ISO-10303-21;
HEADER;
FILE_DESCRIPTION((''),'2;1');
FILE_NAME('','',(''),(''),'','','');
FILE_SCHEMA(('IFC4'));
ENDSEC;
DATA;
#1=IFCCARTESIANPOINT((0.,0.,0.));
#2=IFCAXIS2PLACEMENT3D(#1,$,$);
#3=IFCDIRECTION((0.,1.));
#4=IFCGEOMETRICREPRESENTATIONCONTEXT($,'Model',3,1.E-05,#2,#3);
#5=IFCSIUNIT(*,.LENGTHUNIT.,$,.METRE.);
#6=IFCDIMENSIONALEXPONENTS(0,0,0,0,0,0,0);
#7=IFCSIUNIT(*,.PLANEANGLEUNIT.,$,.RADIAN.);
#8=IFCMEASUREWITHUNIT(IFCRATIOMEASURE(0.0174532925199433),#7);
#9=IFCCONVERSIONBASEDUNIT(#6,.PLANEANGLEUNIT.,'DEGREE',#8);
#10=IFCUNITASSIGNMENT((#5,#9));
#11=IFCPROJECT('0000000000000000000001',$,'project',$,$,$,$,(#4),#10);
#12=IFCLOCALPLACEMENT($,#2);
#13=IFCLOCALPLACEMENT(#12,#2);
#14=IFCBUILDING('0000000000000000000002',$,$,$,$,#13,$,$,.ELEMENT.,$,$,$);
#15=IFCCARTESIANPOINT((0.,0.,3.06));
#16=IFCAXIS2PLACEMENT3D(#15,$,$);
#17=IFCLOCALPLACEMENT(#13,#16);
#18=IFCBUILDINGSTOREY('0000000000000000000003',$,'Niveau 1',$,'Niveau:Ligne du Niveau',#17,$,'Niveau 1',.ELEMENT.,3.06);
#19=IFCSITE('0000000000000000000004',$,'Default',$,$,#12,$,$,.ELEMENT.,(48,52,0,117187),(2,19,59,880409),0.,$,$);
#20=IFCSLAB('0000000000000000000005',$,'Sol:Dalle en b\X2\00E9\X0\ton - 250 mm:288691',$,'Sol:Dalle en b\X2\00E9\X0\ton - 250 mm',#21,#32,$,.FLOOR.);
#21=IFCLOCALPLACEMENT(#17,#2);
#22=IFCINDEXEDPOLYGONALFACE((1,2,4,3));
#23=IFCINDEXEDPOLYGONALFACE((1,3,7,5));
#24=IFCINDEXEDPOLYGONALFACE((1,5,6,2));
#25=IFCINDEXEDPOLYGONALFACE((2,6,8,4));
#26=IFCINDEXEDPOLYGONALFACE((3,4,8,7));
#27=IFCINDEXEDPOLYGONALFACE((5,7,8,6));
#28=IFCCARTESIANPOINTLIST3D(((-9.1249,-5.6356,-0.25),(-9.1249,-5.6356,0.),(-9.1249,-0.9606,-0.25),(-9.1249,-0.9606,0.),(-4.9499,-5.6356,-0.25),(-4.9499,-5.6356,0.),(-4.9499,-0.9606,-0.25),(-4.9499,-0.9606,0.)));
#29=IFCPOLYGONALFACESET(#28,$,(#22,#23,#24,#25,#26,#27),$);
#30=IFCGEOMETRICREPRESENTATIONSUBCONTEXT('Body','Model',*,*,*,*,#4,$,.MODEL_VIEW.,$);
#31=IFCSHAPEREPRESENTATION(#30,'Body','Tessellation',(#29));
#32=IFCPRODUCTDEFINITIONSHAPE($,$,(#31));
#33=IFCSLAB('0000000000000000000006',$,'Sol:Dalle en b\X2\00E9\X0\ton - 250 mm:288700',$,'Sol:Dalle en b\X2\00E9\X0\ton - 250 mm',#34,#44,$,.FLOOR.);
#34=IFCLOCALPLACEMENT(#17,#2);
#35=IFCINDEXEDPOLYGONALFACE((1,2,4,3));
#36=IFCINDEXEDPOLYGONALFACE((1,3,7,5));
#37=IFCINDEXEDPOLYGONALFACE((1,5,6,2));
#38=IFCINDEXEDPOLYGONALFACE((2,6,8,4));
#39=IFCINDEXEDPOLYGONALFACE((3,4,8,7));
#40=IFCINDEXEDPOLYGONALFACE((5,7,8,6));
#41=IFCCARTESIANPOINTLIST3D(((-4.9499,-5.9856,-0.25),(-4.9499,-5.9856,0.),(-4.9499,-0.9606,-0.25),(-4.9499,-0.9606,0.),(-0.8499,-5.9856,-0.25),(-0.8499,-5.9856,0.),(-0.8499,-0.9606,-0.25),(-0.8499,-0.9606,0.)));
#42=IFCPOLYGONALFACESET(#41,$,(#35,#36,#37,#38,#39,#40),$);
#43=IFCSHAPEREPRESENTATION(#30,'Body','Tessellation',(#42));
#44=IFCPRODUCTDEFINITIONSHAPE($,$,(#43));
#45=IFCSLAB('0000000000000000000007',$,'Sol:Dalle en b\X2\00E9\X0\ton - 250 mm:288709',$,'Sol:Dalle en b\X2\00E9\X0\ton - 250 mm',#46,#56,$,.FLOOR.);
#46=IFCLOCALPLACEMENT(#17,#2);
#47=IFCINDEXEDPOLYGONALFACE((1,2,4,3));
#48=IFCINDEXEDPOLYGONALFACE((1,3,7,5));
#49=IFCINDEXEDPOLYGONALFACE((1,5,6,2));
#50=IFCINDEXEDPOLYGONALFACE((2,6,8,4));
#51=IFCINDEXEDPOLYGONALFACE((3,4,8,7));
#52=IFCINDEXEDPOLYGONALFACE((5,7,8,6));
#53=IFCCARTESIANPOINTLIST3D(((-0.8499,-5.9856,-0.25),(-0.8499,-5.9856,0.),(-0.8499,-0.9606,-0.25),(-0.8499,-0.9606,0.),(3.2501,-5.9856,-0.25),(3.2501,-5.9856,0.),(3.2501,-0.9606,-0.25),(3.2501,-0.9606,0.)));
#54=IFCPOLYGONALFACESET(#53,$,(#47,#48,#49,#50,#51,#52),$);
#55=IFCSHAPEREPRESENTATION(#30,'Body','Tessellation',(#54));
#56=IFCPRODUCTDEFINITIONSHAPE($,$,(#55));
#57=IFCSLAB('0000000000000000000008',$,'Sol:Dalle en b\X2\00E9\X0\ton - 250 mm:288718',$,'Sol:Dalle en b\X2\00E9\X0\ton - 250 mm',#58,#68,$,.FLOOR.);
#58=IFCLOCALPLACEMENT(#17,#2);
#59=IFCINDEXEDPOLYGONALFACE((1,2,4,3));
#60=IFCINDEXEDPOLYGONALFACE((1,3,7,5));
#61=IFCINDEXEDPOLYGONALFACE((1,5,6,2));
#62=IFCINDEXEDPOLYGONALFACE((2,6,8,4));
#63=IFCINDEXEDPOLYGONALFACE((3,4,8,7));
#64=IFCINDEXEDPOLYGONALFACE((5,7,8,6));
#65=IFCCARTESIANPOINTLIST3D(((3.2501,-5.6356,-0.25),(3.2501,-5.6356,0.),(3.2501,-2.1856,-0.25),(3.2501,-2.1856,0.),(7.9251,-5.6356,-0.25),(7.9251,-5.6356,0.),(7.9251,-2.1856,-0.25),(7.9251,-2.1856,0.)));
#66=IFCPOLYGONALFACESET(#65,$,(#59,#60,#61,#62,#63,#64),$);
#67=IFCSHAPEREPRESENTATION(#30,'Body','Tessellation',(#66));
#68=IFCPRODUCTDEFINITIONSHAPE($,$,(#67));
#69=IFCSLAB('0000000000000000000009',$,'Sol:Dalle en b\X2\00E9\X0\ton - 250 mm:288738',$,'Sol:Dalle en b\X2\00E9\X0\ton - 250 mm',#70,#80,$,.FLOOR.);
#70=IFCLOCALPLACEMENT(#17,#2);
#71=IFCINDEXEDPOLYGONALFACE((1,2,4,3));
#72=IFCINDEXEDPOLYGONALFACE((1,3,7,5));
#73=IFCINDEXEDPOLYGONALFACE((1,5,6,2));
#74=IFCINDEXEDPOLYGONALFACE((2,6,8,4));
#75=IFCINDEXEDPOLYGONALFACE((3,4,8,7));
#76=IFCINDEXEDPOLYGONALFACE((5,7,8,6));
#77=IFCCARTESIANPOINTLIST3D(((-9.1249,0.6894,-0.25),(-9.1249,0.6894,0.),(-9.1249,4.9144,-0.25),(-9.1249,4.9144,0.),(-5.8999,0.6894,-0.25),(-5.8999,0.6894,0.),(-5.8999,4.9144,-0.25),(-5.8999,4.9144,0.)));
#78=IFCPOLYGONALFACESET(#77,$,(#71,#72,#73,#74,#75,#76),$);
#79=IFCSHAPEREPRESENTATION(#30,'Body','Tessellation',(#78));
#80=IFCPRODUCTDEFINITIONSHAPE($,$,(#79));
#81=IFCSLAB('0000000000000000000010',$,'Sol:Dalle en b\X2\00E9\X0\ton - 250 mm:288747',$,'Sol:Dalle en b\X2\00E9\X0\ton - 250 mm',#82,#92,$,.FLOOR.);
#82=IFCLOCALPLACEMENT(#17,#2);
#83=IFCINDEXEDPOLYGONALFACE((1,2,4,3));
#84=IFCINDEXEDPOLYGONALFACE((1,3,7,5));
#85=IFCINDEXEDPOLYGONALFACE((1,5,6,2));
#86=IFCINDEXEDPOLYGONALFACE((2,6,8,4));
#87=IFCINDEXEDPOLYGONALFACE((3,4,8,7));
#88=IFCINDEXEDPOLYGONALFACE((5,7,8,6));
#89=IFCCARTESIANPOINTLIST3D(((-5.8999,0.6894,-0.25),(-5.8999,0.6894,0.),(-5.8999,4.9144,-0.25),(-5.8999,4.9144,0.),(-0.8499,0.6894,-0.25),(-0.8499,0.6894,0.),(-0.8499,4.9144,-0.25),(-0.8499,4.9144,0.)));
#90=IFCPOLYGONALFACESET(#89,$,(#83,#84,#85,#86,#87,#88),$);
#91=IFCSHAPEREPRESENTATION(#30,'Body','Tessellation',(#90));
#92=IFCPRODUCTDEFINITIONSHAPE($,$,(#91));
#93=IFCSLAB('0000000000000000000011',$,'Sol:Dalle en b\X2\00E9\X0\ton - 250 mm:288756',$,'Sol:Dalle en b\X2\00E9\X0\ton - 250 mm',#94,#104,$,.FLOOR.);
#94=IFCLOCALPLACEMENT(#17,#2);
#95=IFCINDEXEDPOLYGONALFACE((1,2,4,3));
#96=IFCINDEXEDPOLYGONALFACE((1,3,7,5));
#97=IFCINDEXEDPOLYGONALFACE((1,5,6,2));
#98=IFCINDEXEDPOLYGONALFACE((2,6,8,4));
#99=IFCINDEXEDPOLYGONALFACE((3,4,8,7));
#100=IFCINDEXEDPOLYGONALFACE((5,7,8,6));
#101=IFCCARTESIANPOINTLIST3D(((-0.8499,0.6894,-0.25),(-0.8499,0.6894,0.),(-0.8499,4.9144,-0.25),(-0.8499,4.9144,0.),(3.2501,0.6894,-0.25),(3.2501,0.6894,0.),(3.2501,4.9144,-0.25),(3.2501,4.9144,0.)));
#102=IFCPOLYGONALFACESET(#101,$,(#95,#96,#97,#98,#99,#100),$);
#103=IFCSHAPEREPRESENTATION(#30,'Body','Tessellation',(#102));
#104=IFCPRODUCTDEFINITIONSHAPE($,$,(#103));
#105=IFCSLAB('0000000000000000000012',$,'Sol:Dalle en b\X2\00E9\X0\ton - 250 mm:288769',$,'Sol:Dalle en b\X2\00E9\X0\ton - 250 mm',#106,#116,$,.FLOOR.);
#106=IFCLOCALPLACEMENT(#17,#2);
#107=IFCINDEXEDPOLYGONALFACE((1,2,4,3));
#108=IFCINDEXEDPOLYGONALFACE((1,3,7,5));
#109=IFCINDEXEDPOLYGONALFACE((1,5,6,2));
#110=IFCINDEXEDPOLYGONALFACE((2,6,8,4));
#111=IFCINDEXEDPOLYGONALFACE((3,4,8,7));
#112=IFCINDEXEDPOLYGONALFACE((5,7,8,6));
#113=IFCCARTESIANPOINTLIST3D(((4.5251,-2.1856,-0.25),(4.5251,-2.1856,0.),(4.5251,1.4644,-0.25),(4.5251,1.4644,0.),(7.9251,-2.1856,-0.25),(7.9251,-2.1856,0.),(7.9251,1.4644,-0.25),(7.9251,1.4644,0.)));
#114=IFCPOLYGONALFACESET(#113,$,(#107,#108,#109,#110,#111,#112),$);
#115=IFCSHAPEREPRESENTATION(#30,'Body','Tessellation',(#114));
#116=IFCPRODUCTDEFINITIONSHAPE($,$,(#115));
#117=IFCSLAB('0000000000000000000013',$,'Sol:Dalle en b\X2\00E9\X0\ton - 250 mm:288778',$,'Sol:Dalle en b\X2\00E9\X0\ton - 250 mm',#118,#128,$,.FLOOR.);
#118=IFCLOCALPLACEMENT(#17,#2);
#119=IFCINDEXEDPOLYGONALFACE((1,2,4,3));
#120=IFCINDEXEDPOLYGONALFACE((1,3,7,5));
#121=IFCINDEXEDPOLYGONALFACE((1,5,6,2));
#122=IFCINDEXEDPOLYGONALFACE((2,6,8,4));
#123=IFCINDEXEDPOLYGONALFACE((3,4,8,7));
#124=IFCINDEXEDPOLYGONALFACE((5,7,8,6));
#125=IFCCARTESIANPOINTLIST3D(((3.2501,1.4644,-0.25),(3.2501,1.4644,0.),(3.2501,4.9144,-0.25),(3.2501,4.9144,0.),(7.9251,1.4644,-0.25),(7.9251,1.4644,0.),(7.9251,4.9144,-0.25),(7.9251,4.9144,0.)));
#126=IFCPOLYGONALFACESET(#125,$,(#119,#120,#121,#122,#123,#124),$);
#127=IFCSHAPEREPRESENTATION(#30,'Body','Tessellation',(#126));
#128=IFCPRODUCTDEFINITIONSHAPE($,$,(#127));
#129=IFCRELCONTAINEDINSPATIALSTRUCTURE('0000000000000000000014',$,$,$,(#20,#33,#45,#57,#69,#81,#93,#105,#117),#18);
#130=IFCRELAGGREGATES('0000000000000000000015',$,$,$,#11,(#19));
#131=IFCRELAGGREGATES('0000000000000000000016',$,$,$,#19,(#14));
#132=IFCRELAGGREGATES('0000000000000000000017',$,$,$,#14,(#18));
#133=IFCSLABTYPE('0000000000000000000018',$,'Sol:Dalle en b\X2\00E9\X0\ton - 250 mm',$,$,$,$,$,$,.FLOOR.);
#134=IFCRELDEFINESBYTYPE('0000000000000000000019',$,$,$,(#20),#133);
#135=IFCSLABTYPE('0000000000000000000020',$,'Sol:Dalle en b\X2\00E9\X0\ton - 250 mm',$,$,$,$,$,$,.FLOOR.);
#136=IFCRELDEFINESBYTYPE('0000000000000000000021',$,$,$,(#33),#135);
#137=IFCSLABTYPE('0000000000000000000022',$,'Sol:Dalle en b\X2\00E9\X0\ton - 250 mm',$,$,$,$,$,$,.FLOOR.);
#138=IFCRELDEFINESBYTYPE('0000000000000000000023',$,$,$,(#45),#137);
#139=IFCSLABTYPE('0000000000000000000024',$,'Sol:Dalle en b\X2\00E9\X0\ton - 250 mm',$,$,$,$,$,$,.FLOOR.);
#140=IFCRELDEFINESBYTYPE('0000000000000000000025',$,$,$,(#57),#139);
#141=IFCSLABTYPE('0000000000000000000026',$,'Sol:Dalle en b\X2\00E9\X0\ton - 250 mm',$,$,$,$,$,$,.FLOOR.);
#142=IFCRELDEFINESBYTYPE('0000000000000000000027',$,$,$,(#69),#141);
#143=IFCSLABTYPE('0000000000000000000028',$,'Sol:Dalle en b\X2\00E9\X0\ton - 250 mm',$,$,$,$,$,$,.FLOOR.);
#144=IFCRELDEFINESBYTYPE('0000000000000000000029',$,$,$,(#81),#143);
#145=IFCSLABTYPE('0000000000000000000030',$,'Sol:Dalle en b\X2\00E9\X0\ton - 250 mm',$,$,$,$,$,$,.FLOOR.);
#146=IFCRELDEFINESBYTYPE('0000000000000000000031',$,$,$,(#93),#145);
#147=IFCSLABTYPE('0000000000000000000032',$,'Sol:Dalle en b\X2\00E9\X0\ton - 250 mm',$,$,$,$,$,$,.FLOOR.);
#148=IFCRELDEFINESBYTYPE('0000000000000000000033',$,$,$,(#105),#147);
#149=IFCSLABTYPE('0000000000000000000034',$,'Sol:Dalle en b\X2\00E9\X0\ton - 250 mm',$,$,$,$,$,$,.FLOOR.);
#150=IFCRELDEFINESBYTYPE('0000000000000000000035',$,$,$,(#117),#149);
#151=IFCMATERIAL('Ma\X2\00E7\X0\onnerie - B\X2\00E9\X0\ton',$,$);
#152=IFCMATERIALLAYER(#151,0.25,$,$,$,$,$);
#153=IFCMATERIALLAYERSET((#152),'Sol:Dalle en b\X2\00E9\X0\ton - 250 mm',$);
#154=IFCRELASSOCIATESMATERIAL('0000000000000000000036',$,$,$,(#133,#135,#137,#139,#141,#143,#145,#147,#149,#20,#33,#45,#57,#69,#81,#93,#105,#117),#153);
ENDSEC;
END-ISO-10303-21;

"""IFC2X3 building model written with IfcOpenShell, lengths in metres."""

from ifc_helpers import new_model, entity, si_unit, converted_unit, direction, frame, frame_2d, origin, origin_2d_with_axis, place, context, subcontext, project, spatial, rectangle, extrude, material, layer, layer_set, layer_usage, type_object, element, save


model = new_model("IFC2X3")

# Units and contexts
model_context = context("Model", 3, precision=1e-05, world=origin(), true_north=direction((0.0, 1.0)))
body_context = subcontext(model_context, "Body", "Model", "MODEL_VIEW")
ifc_project = project(units=[si_unit("LENGTHUNIT", "METRE"), converted_unit("PLANEANGLEUNIT", "DEGREE", entity("IfcRatioMeasure", 0.0174532925199433), si_unit("PLANEANGLEUNIT", "RADIAN"), dimensions=[0, 0, 0, 0, 0, 0, 0])], contexts=[model_context])

# Site, building, storey
site_placement = place(None, origin())
site = spatial("IfcSite", under=ifc_project, at=site_placement, Name="Default", CompositionType="ELEMENT", RefLatitude=(48, 52, 0, 117187), RefLongitude=(2, 19, 59, 880409), RefElevation=0.0)
building_placement = place(site_placement, origin())
building = spatial("IfcBuilding", under=site, at=building_placement, CompositionType="ELEMENT")
storey_placement = place(building_placement, frame((0.0, 0.0, 3.06)))
storey = spatial("IfcBuildingStorey", under=building, at=storey_placement, Name="Niveau 1", ObjectType="Niveau:Ligne du Niveau", LongName="Niveau 1", CompositionType="ELEMENT", Elevation=3.06)

# Slabs
ifc_material = material(Name="Maçonnerie - Béton")
ifc_layer = layer(ifc_material, 0.25)
ifc_layer_set = layer_set([ifc_layer], Name="Sol:Dalle en béton - 250 mm")
ifc_layer_usage_1 = layer_usage(ifc_layer_set, "AXIS3", "POSITIVE", 0.0)
slab_type_1 = type_object("IfcSlabType", Name="Sol:Dalle en béton - 250 mm", PredefinedType="FLOOR", material=ifc_layer_set)
slab_1_placement = place(storey_placement, origin())
element("IfcSlab", 1, at=slab_1_placement, inside=storey, type_object=slab_type_1, material=ifc_layer_usage_1, Name="Sol:Dalle en béton - 250 mm:288691", ObjectType="Sol:Dalle en béton - 250 mm", PredefinedType="FLOOR", context=body_context, shape_type="SweptSolid", body=[
    extrude(rectangle(XDim=4.675, YDim=4.175, at=frame_2d((0.0, 0.0), x_axis=(1.0, 0.0))), frame((-7.0374, -3.2981, 0.0), z_axis=(0.0, 0.0, -1.0), x_axis=(0.0, 1.0, 0.0)), (0.0, 0.0, 1.0), 0.25),
])
ifc_layer_usage_2 = layer_usage(ifc_layer_set, "AXIS3", "POSITIVE", 0.0)
slab_type_2 = type_object("IfcSlabType", Name="Sol:Dalle en béton - 250 mm", PredefinedType="FLOOR", material=ifc_layer_set)
slab_2_placement = place(storey_placement, origin())
element("IfcSlab", 2, at=slab_2_placement, inside=storey, type_object=slab_type_2, material=ifc_layer_usage_2, Name="Sol:Dalle en béton - 250 mm:288700", ObjectType="Sol:Dalle en béton - 250 mm", PredefinedType="FLOOR", context=body_context, shape_type="SweptSolid", body=[
    extrude(rectangle(XDim=5.025, YDim=4.1, at=frame_2d((0.0, 0.0), x_axis=(1.0, 0.0))), frame((-2.8999, -3.4731, 0.0), z_axis=(0.0, 0.0, -1.0), x_axis=(0.0, 1.0, 0.0)), (0.0, 0.0, 1.0), 0.25),
])
ifc_layer_usage_3 = layer_usage(ifc_layer_set, "AXIS3", "POSITIVE", 0.0)
slab_type_3 = type_object("IfcSlabType", Name="Sol:Dalle en béton - 250 mm", PredefinedType="FLOOR", material=ifc_layer_set)
slab_3_placement = place(storey_placement, origin())
element("IfcSlab", 3, at=slab_3_placement, inside=storey, type_object=slab_type_3, material=ifc_layer_usage_3, Name="Sol:Dalle en béton - 250 mm:288709", ObjectType="Sol:Dalle en béton - 250 mm", PredefinedType="FLOOR", context=body_context, shape_type="SweptSolid", body=[
    extrude(rectangle(XDim=5.025, YDim=4.1, at=origin_2d_with_axis()), frame((1.2001, -3.4731, 0.0), z_axis=(0.0, 0.0, -1.0), x_axis=(0.0, 1.0, 0.0)), (0.0, 0.0, 1.0), 0.25),
])
ifc_layer_usage_4 = layer_usage(ifc_layer_set, "AXIS3", "POSITIVE", 0.0)
slab_type_4 = type_object("IfcSlabType", Name="Sol:Dalle en béton - 250 mm", PredefinedType="FLOOR", material=ifc_layer_set)
slab_4_placement = place(storey_placement, origin())
element("IfcSlab", 4, at=slab_4_placement, inside=storey, type_object=slab_type_4, material=ifc_layer_usage_4, Name="Sol:Dalle en béton - 250 mm:288718", ObjectType="Sol:Dalle en béton - 250 mm", PredefinedType="FLOOR", context=body_context, shape_type="SweptSolid", body=[
    extrude(rectangle(XDim=3.45, YDim=4.675, at=frame_2d((0.0, 0.0), x_axis=(1.0, 0.0))), frame((5.5876, -3.9106, 0.0), z_axis=(0.0, 0.0, -1.0), x_axis=(0.0, 1.0, 0.0)), (0.0, 0.0, 1.0), 0.25),
])
ifc_layer_usage_5 = layer_usage(ifc_layer_set, "AXIS3", "POSITIVE", 0.0)
slab_type_5 = type_object("IfcSlabType", Name="Sol:Dalle en béton - 250 mm", PredefinedType="FLOOR", material=ifc_layer_set)
slab_5_placement = place(storey_placement, origin())
element("IfcSlab", 5, at=slab_5_placement, inside=storey, type_object=slab_type_5, material=ifc_layer_usage_5, Name="Sol:Dalle en béton - 250 mm:288738", ObjectType="Sol:Dalle en béton - 250 mm", PredefinedType="FLOOR", context=body_context, shape_type="SweptSolid", body=[
    extrude(rectangle(XDim=4.225, YDim=3.225, at=frame_2d((0.0, 0.0), x_axis=(1.0, 0.0))), frame((-7.5124, 2.8019, 0.0), z_axis=(0.0, 0.0, -1.0), x_axis=(0.0, 1.0, 0.0)), (0.0, 0.0, 1.0), 0.25),
])
ifc_layer_usage_6 = layer_usage(ifc_layer_set, "AXIS3", "POSITIVE", 0.0)
slab_type_6 = type_object("IfcSlabType", Name="Sol:Dalle en béton - 250 mm", PredefinedType="FLOOR", material=ifc_layer_set)
slab_6_placement = place(storey_placement, origin())
element("IfcSlab", 6, at=slab_6_placement, inside=storey, type_object=slab_type_6, material=ifc_layer_usage_6, Name="Sol:Dalle en béton - 250 mm:288747", ObjectType="Sol:Dalle en béton - 250 mm", PredefinedType="FLOOR", context=body_context, shape_type="SweptSolid", body=[
    extrude(rectangle(XDim=4.225, YDim=5.05, at=frame_2d((0.0, 0.0), x_axis=(1.0, 0.0))), frame((-3.3749, 2.8019, 0.0), z_axis=(0.0, 0.0, -1.0), x_axis=(0.0, 1.0, 0.0)), (0.0, 0.0, 1.0), 0.25),
])
ifc_layer_usage_7 = layer_usage(ifc_layer_set, "AXIS3", "POSITIVE", 0.0)
slab_type_7 = type_object("IfcSlabType", Name="Sol:Dalle en béton - 250 mm", PredefinedType="FLOOR", material=ifc_layer_set)
slab_7_placement = place(storey_placement, origin())
element("IfcSlab", 7, at=slab_7_placement, inside=storey, type_object=slab_type_7, material=ifc_layer_usage_7, Name="Sol:Dalle en béton - 250 mm:288756", ObjectType="Sol:Dalle en béton - 250 mm", PredefinedType="FLOOR", context=body_context, shape_type="SweptSolid", body=[
    extrude(rectangle(XDim=4.225, YDim=4.1, at=frame_2d((0.0, 0.0), x_axis=(1.0, 0.0))), frame((1.2001, 2.8019, 0.0), z_axis=(0.0, 0.0, -1.0), x_axis=(0.0, 1.0, 0.0)), (0.0, 0.0, 1.0), 0.25),
])
ifc_layer_usage_8 = layer_usage(ifc_layer_set, "AXIS3", "POSITIVE", 0.0)
slab_type_8 = type_object("IfcSlabType", Name="Sol:Dalle en béton - 250 mm", PredefinedType="FLOOR", material=ifc_layer_set)
slab_8_placement = place(storey_placement, origin())
element("IfcSlab", 8, at=slab_8_placement, inside=storey, type_object=slab_type_8, material=ifc_layer_usage_8, Name="Sol:Dalle en béton - 250 mm:288769", ObjectType="Sol:Dalle en béton - 250 mm", PredefinedType="FLOOR", context=body_context, shape_type="SweptSolid", body=[
    extrude(rectangle(XDim=3.65, YDim=3.4, at=frame_2d((0.0, 0.0), x_axis=(1.0, 0.0))), frame((6.2251, -0.3606, 0.0), z_axis=(0.0, 0.0, -1.0), x_axis=(0.0, 1.0, 0.0)), (0.0, 0.0, 1.0), 0.25),
])
ifc_layer_usage_9 = layer_usage(ifc_layer_set, "AXIS3", "POSITIVE", 0.0)
slab_type_9 = type_object("IfcSlabType", Name="Sol:Dalle en béton - 250 mm", PredefinedType="FLOOR", material=ifc_layer_set)
slab_9_placement = place(storey_placement, origin())
element("IfcSlab", 9, at=slab_9_placement, inside=storey, type_object=slab_type_9, material=ifc_layer_usage_9, Name="Sol:Dalle en béton - 250 mm:288778", ObjectType="Sol:Dalle en béton - 250 mm", PredefinedType="FLOOR", context=body_context, shape_type="SweptSolid", body=[
    extrude(rectangle(XDim=3.45, YDim=4.675, at=frame_2d((0.0, 0.0), x_axis=(1.0, 0.0))), frame((5.5876, 3.1894, 0.0), z_axis=(0.0, 0.0, -1.0), x_axis=(0.0, 1.0, 0.0)), (0.0, 0.0, 1.0), 0.25),
])

save(model, "model.ifc")
